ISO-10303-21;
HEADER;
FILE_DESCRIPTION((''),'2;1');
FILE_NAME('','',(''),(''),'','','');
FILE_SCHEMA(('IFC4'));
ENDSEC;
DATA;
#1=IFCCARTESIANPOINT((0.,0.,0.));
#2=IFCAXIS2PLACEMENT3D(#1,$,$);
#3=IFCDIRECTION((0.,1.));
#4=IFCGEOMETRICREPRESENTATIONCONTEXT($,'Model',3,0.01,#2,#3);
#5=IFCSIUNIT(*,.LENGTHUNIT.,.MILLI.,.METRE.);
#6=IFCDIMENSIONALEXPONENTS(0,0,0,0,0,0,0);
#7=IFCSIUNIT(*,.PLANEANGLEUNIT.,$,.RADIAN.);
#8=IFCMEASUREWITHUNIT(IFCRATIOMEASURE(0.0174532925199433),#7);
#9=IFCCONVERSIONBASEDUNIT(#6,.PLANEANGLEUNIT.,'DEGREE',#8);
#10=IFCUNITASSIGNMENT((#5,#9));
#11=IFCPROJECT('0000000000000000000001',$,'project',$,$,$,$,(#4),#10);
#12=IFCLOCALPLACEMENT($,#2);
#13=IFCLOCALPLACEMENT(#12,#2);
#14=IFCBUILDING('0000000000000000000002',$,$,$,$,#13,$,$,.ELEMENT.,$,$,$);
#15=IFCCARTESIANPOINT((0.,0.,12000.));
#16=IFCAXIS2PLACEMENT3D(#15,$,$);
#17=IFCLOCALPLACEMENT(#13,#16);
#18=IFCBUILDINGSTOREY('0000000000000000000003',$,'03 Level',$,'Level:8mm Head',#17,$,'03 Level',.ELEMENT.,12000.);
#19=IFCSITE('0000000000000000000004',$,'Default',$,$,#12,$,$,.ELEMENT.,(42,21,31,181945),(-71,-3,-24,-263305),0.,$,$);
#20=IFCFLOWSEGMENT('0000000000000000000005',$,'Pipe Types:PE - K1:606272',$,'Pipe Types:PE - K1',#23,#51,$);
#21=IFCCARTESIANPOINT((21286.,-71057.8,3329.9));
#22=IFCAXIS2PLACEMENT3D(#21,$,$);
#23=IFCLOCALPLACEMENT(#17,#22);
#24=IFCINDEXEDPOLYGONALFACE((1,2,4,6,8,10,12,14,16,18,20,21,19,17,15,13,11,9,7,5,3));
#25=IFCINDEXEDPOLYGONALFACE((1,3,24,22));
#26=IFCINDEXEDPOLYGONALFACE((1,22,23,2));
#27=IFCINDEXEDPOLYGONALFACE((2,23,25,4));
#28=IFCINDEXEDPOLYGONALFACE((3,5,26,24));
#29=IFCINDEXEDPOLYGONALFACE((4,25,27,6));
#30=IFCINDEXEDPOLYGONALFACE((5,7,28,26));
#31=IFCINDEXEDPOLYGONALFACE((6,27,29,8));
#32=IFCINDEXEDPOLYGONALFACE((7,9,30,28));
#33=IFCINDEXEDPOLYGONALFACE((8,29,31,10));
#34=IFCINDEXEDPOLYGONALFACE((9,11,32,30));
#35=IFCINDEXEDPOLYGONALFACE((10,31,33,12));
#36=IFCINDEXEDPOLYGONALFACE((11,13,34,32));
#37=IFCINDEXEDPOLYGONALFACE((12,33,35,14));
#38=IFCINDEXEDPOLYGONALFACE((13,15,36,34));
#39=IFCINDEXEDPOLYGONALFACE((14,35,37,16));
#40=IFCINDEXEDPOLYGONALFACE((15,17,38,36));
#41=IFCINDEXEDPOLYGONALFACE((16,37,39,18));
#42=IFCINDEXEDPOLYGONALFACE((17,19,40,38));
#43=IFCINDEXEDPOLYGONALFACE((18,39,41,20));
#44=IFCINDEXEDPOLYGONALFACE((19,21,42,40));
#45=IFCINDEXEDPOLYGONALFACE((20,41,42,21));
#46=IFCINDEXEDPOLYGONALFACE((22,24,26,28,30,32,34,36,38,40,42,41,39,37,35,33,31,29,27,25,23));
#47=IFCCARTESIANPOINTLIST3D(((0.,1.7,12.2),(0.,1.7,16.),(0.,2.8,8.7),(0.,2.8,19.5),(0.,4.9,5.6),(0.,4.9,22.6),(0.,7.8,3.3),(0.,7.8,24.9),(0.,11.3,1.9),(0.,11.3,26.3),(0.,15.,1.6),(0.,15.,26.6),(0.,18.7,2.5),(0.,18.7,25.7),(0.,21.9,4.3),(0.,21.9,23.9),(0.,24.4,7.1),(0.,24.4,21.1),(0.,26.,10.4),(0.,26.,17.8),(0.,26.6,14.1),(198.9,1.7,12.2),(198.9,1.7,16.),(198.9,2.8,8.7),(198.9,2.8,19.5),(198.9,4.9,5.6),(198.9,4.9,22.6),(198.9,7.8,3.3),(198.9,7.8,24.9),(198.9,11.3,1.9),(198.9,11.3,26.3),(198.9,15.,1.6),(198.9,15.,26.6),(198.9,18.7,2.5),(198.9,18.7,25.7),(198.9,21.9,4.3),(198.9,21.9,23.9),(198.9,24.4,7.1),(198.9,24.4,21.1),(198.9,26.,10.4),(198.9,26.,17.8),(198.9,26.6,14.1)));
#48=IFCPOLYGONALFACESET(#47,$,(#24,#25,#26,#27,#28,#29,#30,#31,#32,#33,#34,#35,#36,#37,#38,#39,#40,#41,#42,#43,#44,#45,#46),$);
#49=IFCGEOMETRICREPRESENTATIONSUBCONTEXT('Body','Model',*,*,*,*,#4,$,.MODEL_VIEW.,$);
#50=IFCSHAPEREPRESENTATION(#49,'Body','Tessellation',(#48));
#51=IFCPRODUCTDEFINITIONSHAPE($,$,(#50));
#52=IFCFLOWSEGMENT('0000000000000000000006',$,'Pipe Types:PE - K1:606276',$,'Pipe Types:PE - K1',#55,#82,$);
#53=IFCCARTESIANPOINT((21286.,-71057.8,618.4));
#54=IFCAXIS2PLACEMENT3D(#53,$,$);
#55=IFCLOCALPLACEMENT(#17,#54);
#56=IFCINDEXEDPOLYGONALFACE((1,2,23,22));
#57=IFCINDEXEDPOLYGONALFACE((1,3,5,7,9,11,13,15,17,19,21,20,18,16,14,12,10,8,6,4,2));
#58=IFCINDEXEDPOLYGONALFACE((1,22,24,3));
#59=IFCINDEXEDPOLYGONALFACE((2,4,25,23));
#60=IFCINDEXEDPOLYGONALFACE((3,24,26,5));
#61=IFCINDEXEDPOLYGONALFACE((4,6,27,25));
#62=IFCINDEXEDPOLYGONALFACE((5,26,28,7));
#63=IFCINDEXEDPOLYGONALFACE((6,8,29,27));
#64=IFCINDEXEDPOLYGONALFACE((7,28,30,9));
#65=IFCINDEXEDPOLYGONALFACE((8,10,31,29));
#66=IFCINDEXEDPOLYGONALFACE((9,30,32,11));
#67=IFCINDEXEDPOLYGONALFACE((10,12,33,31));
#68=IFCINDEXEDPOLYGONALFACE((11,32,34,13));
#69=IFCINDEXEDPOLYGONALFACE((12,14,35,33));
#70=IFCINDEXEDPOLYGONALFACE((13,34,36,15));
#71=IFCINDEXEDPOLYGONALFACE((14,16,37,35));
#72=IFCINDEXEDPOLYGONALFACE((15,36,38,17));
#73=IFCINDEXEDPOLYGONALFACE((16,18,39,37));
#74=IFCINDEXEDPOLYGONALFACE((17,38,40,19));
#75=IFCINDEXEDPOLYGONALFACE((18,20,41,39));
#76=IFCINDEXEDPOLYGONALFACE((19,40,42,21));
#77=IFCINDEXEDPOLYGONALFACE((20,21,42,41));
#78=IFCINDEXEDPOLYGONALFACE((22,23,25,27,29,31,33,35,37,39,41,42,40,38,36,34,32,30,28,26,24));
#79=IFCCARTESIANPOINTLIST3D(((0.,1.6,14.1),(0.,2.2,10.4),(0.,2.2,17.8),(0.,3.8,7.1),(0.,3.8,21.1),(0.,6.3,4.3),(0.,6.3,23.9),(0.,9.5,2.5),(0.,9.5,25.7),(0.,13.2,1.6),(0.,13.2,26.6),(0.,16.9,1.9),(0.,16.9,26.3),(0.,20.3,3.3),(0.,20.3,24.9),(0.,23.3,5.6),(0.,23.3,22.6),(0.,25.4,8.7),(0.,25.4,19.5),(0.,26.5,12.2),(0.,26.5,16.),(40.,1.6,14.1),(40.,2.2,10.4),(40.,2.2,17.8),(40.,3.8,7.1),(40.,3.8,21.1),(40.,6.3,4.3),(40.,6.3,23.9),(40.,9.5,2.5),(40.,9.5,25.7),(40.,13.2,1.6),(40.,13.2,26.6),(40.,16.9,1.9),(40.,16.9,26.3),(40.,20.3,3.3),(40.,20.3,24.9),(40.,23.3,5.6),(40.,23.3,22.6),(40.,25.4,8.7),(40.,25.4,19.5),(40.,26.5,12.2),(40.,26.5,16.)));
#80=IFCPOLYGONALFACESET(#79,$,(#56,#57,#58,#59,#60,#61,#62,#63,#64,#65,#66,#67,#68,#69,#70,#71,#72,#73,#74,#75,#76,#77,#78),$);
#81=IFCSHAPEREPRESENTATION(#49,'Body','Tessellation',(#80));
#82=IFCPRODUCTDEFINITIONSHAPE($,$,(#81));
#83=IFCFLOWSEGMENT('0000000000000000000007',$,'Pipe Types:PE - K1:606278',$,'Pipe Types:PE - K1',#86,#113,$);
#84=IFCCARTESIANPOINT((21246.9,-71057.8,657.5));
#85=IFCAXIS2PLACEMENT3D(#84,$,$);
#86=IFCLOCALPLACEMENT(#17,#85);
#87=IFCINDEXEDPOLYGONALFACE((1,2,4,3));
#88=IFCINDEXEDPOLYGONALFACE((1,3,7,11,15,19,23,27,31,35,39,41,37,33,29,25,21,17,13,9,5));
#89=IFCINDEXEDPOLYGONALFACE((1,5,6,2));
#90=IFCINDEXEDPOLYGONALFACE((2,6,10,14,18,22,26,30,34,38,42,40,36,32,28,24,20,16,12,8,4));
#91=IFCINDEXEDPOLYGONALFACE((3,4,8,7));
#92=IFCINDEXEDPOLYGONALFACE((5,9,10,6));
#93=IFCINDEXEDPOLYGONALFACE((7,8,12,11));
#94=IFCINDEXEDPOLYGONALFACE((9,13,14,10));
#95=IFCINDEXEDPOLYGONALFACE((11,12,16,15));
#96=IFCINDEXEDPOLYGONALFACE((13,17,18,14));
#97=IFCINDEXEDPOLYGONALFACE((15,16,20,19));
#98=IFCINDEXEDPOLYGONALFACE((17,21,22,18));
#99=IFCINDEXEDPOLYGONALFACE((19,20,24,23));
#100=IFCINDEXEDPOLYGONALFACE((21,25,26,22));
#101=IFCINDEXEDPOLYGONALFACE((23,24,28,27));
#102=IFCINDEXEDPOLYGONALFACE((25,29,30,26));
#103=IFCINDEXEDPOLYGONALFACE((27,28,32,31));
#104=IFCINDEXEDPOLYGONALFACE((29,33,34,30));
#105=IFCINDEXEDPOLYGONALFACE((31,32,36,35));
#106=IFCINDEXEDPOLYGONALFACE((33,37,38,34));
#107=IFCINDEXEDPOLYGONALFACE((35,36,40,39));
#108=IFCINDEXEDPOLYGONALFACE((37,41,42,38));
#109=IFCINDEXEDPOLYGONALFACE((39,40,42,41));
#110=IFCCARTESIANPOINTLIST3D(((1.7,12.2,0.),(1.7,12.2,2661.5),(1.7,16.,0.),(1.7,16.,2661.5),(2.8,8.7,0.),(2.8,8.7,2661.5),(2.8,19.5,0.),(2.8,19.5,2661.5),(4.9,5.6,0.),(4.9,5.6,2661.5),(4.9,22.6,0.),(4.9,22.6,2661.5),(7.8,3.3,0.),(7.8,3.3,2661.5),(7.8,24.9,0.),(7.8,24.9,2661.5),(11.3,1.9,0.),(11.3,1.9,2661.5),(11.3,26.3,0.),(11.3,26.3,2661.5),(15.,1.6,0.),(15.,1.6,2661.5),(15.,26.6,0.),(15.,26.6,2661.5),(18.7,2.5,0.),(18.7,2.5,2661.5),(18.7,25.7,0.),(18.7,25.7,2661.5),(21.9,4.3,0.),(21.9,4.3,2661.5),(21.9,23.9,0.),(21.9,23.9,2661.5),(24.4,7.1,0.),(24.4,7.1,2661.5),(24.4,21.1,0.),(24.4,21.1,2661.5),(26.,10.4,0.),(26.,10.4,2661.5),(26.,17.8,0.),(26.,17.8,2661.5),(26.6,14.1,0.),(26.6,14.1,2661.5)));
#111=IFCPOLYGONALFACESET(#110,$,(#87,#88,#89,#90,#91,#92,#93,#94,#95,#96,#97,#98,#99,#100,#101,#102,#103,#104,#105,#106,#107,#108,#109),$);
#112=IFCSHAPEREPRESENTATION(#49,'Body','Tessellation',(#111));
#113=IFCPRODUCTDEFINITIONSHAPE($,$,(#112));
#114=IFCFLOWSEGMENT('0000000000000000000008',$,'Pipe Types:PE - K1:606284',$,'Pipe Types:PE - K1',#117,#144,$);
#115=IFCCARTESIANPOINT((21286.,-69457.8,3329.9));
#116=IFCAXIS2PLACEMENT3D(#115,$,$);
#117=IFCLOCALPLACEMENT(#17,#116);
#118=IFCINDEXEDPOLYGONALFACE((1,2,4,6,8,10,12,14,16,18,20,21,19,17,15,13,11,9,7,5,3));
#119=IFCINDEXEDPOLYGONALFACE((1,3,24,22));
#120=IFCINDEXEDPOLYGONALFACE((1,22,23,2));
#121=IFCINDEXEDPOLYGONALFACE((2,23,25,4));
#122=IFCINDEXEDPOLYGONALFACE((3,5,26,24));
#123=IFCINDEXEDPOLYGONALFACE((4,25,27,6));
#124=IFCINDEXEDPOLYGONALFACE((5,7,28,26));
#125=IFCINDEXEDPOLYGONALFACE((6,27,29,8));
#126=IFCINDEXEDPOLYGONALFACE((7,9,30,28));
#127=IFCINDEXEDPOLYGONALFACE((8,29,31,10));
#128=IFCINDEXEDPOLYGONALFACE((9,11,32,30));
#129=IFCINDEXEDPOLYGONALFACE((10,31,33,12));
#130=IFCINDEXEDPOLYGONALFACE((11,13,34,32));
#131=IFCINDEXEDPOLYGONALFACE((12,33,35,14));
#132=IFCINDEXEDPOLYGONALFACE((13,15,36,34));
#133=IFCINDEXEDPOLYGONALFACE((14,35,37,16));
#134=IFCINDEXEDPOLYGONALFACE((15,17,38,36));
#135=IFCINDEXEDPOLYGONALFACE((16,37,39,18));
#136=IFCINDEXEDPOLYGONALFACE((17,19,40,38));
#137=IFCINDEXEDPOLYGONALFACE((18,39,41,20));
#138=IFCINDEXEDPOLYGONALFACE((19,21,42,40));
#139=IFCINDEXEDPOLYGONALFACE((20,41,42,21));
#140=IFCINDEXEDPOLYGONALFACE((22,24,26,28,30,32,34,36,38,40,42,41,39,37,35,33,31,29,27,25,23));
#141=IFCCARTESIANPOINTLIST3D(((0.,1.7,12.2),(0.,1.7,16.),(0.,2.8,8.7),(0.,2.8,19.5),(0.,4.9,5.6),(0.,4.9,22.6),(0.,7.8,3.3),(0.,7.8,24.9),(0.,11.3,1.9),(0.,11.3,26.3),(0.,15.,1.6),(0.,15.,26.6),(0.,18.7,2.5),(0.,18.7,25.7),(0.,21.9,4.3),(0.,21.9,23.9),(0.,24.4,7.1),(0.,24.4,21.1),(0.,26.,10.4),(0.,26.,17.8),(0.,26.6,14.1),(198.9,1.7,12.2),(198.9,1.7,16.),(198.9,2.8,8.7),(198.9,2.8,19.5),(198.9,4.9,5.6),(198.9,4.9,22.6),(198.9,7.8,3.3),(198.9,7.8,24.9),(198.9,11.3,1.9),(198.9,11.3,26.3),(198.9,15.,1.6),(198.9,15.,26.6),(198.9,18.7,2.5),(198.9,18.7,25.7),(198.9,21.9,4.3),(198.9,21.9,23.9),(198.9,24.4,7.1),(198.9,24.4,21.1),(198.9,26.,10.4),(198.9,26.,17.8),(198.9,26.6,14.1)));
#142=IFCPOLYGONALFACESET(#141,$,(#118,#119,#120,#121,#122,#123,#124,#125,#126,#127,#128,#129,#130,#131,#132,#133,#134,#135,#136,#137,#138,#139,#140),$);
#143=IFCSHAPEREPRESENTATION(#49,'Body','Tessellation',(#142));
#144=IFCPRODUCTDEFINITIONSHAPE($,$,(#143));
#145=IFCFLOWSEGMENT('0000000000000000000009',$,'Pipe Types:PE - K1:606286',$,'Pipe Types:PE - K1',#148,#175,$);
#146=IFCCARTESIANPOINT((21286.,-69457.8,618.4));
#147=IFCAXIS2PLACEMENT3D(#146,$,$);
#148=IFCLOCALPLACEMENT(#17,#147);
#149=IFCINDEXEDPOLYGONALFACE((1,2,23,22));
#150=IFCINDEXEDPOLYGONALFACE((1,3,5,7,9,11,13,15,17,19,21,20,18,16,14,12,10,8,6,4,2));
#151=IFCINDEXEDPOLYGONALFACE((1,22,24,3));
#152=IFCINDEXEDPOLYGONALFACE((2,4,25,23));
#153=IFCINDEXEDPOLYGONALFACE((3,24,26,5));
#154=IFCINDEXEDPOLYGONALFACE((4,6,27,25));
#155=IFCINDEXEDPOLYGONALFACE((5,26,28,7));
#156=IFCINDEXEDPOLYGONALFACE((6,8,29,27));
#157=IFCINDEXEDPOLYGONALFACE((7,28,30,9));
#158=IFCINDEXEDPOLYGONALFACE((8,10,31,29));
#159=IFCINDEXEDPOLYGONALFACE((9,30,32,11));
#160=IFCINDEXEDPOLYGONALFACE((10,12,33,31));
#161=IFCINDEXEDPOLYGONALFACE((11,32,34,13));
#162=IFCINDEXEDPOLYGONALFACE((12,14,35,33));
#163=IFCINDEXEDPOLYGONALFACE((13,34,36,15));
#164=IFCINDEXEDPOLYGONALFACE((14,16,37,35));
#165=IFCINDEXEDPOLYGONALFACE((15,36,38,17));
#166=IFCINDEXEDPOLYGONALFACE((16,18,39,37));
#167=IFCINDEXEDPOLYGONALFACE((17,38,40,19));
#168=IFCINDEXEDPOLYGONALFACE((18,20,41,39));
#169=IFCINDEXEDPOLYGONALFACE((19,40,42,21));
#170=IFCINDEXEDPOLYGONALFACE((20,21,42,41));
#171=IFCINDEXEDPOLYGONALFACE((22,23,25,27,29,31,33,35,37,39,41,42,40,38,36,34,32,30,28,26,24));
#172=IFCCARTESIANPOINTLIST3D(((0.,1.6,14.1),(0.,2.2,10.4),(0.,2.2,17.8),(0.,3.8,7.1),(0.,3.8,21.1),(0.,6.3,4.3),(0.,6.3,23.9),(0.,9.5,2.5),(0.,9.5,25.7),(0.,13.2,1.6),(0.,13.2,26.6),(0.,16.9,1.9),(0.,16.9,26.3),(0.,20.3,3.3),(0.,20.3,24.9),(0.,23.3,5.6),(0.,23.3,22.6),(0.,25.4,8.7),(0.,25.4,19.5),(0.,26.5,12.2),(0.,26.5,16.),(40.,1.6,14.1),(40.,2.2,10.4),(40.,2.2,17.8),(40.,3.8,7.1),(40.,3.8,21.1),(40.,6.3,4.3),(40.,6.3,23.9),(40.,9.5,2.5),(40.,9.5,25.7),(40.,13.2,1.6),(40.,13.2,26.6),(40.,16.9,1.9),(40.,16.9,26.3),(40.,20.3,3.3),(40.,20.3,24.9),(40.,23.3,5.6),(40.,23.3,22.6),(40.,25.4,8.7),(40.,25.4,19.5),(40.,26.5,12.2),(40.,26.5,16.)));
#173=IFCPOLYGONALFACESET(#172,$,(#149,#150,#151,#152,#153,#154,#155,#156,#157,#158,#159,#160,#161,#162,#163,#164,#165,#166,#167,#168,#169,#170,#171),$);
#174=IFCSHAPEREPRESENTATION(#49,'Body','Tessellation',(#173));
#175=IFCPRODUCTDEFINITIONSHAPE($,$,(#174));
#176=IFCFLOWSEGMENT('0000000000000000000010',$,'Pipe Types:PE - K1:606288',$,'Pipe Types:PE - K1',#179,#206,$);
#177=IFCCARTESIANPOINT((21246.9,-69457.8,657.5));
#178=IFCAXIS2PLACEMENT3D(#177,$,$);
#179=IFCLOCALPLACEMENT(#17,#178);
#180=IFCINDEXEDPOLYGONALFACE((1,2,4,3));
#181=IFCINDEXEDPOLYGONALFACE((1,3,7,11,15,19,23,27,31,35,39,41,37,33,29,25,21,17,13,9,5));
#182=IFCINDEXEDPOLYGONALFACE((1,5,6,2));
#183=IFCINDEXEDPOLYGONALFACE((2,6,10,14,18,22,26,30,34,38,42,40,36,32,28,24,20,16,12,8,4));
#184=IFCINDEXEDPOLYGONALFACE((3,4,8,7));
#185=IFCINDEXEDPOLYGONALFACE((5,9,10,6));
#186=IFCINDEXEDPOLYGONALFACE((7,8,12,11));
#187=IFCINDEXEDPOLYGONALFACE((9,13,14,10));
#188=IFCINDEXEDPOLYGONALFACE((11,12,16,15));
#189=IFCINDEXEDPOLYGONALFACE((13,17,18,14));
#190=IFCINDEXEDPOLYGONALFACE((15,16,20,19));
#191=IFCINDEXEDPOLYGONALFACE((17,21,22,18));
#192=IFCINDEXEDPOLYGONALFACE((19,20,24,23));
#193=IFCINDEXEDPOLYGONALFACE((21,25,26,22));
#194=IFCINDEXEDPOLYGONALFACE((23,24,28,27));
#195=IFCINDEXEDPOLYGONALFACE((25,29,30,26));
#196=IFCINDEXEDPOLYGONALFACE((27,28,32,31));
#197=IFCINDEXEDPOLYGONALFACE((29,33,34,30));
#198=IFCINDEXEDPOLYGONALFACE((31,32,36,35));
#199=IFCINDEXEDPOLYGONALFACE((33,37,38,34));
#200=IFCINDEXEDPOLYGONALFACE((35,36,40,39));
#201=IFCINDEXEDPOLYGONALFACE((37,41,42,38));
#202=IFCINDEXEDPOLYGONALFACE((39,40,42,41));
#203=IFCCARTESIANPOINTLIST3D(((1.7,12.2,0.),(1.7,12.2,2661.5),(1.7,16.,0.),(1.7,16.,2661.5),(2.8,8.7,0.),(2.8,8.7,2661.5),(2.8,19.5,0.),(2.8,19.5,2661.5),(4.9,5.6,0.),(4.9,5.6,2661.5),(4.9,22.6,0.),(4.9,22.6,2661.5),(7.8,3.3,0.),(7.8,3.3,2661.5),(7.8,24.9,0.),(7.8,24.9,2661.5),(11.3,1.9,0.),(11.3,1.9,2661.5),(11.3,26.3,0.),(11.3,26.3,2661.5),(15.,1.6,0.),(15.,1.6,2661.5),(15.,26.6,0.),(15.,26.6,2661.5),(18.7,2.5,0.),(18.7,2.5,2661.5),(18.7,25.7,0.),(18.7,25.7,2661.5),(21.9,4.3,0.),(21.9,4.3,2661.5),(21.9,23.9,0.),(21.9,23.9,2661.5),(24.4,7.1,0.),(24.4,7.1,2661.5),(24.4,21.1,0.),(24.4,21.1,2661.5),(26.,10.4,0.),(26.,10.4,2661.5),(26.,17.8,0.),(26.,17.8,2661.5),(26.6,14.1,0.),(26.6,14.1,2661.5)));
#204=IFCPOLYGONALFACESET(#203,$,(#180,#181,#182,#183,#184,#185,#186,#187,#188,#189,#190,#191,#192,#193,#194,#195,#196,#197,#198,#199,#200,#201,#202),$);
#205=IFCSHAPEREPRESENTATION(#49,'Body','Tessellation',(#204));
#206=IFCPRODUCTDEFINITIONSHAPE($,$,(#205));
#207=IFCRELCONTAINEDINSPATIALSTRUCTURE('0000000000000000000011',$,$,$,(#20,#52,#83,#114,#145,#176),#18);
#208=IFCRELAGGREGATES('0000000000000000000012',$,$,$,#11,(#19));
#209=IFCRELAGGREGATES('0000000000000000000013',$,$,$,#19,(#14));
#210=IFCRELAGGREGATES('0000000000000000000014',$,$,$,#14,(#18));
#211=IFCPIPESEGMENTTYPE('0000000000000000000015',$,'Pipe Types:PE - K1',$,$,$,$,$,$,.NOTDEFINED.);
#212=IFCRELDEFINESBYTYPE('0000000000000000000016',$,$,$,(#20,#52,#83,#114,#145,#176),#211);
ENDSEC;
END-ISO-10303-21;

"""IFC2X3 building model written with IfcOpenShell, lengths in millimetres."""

from ifc_helpers import new_model, entity, si_unit, converted_unit, direction, frame, frame_2d, origin, origin_2d_with_axis, place, context, subcontext, project, spatial, circle, extrude, type_object, element, save


model = new_model("IFC2X3")

# Units and contexts
model_context = context("Model", 3, precision=0.01, world=origin(), true_north=direction((0.0, 1.0)))
body_context = subcontext(model_context, "Body", "Model", "MODEL_VIEW")
ifc_project = project(units=[si_unit("LENGTHUNIT", "METRE", prefix="MILLI"), converted_unit("PLANEANGLEUNIT", "DEGREE", entity("IfcRatioMeasure", 0.0174532925199433), si_unit("PLANEANGLEUNIT", "RADIAN"), dimensions=[0, 0, 0, 0, 0, 0, 0])], contexts=[model_context])

# Site, building, storey
site_placement = place(None, origin())
site = spatial("IfcSite", under=ifc_project, at=site_placement, Name="Default", CompositionType="ELEMENT", RefLatitude=(42, 21, 31, 181945), RefLongitude=(-71, -3, -24, -263305), RefElevation=0.0)
building_placement = place(site_placement, origin())
building = spatial("IfcBuilding", under=site, at=building_placement, CompositionType="ELEMENT")
storey_placement = place(building_placement, frame((0.0, 0.0, 12000.0)))
storey = spatial("IfcBuildingStorey", under=building, at=storey_placement, Name="03 Level", ObjectType="Level:8mm Head", LongName="03 Level", CompositionType="ELEMENT", Elevation=12000.0)

# Flow segments
pipe_segment_type = type_object("IfcPipeSegmentType", Name="Pipe Types:PE - K1", PredefinedType="NOTDEFINED")
flow_segment_1_placement = place(storey_placement, frame((21286.0, -71057.8, 3329.9)))
element("IfcFlowSegment", 1, at=flow_segment_1_placement, inside=storey, type_object=pipe_segment_type, Name="Pipe Types:PE - K1:606272", ObjectType="Pipe Types:PE - K1", context=body_context, shape_type="SweptSolid", body=[
    extrude(circle(Radius=12.5, at=frame_2d((0.0, 0.0), x_axis=(1.0, 0.0))), frame((0.0, 14.1, 14.1), z_axis=(1.0, 0.0, 0.0), x_axis=(0.0, 1.0, 0.0)), (0.0, 0.0, 1.0), 198.9),
])
flow_segment_2_placement = place(storey_placement, frame((21286.0, -71057.8, 618.4)))
element("IfcFlowSegment", 2, at=flow_segment_2_placement, inside=storey, type_object=pipe_segment_type, Name="Pipe Types:PE - K1:606276", ObjectType="Pipe Types:PE - K1", context=body_context, shape_type="SweptSolid", body=[
    extrude(circle(Radius=12.5, at=origin_2d_with_axis()), frame((0.0, 14.1, 14.1), z_axis=(1.0, 0.0, 0.0), x_axis=(0.0, -1.0, 0.0)), (0.0, 0.0, 1.0), 40.0),
])
flow_segment_3_placement = place(storey_placement, frame((21246.9, -71057.8, 657.5)))
element("IfcFlowSegment", 3, at=flow_segment_3_placement, inside=storey, type_object=pipe_segment_type, Name="Pipe Types:PE - K1:606278", ObjectType="Pipe Types:PE - K1", context=body_context, shape_type="SweptSolid", body=[
    extrude(circle(Radius=12.5, at=frame_2d((0.0, 0.0), x_axis=(1.0, 0.0))), frame((14.1, 14.1, 0.0)), (0.0, 0.0, 1.0), 2661.5),
])
flow_segment_4_placement = place(storey_placement, frame((21286.0, -69457.8, 3329.9)))
element("IfcFlowSegment", 4, at=flow_segment_4_placement, inside=storey, type_object=pipe_segment_type, Name="Pipe Types:PE - K1:606284", ObjectType="Pipe Types:PE - K1", context=body_context, shape_type="SweptSolid", body=[
    extrude(circle(Radius=12.5, at=frame_2d((0.0, 0.0), x_axis=(1.0, 0.0))), frame((0.0, 14.1, 14.1), z_axis=(1.0, 0.0, 0.0), x_axis=(0.0, 1.0, 0.0)), (0.0, 0.0, 1.0), 198.9),
])
flow_segment_5_placement = place(storey_placement, frame((21286.0, -69457.8, 618.4)))
element("IfcFlowSegment", 5, at=flow_segment_5_placement, inside=storey, type_object=pipe_segment_type, Name="Pipe Types:PE - K1:606286", ObjectType="Pipe Types:PE - K1", context=body_context, shape_type="SweptSolid", body=[
    extrude(circle(Radius=12.5, at=origin_2d_with_axis()), frame((0.0, 14.1, 14.1), z_axis=(1.0, 0.0, 0.0), x_axis=(0.0, -1.0, 0.0)), (0.0, 0.0, 1.0), 40.0),
])
flow_segment_6_placement = place(storey_placement, frame((21246.9, -69457.8, 657.5)))
element("IfcFlowSegment", 6, at=flow_segment_6_placement, inside=storey, type_object=pipe_segment_type, Name="Pipe Types:PE - K1:606288", ObjectType="Pipe Types:PE - K1", context=body_context, shape_type="SweptSolid", body=[
    extrude(circle(Radius=12.5, at=origin_2d_with_axis()), frame((14.1, 14.1, 0.0)), (0.0, 0.0, 1.0), 2661.5),
])

save(model, "model.ifc")
